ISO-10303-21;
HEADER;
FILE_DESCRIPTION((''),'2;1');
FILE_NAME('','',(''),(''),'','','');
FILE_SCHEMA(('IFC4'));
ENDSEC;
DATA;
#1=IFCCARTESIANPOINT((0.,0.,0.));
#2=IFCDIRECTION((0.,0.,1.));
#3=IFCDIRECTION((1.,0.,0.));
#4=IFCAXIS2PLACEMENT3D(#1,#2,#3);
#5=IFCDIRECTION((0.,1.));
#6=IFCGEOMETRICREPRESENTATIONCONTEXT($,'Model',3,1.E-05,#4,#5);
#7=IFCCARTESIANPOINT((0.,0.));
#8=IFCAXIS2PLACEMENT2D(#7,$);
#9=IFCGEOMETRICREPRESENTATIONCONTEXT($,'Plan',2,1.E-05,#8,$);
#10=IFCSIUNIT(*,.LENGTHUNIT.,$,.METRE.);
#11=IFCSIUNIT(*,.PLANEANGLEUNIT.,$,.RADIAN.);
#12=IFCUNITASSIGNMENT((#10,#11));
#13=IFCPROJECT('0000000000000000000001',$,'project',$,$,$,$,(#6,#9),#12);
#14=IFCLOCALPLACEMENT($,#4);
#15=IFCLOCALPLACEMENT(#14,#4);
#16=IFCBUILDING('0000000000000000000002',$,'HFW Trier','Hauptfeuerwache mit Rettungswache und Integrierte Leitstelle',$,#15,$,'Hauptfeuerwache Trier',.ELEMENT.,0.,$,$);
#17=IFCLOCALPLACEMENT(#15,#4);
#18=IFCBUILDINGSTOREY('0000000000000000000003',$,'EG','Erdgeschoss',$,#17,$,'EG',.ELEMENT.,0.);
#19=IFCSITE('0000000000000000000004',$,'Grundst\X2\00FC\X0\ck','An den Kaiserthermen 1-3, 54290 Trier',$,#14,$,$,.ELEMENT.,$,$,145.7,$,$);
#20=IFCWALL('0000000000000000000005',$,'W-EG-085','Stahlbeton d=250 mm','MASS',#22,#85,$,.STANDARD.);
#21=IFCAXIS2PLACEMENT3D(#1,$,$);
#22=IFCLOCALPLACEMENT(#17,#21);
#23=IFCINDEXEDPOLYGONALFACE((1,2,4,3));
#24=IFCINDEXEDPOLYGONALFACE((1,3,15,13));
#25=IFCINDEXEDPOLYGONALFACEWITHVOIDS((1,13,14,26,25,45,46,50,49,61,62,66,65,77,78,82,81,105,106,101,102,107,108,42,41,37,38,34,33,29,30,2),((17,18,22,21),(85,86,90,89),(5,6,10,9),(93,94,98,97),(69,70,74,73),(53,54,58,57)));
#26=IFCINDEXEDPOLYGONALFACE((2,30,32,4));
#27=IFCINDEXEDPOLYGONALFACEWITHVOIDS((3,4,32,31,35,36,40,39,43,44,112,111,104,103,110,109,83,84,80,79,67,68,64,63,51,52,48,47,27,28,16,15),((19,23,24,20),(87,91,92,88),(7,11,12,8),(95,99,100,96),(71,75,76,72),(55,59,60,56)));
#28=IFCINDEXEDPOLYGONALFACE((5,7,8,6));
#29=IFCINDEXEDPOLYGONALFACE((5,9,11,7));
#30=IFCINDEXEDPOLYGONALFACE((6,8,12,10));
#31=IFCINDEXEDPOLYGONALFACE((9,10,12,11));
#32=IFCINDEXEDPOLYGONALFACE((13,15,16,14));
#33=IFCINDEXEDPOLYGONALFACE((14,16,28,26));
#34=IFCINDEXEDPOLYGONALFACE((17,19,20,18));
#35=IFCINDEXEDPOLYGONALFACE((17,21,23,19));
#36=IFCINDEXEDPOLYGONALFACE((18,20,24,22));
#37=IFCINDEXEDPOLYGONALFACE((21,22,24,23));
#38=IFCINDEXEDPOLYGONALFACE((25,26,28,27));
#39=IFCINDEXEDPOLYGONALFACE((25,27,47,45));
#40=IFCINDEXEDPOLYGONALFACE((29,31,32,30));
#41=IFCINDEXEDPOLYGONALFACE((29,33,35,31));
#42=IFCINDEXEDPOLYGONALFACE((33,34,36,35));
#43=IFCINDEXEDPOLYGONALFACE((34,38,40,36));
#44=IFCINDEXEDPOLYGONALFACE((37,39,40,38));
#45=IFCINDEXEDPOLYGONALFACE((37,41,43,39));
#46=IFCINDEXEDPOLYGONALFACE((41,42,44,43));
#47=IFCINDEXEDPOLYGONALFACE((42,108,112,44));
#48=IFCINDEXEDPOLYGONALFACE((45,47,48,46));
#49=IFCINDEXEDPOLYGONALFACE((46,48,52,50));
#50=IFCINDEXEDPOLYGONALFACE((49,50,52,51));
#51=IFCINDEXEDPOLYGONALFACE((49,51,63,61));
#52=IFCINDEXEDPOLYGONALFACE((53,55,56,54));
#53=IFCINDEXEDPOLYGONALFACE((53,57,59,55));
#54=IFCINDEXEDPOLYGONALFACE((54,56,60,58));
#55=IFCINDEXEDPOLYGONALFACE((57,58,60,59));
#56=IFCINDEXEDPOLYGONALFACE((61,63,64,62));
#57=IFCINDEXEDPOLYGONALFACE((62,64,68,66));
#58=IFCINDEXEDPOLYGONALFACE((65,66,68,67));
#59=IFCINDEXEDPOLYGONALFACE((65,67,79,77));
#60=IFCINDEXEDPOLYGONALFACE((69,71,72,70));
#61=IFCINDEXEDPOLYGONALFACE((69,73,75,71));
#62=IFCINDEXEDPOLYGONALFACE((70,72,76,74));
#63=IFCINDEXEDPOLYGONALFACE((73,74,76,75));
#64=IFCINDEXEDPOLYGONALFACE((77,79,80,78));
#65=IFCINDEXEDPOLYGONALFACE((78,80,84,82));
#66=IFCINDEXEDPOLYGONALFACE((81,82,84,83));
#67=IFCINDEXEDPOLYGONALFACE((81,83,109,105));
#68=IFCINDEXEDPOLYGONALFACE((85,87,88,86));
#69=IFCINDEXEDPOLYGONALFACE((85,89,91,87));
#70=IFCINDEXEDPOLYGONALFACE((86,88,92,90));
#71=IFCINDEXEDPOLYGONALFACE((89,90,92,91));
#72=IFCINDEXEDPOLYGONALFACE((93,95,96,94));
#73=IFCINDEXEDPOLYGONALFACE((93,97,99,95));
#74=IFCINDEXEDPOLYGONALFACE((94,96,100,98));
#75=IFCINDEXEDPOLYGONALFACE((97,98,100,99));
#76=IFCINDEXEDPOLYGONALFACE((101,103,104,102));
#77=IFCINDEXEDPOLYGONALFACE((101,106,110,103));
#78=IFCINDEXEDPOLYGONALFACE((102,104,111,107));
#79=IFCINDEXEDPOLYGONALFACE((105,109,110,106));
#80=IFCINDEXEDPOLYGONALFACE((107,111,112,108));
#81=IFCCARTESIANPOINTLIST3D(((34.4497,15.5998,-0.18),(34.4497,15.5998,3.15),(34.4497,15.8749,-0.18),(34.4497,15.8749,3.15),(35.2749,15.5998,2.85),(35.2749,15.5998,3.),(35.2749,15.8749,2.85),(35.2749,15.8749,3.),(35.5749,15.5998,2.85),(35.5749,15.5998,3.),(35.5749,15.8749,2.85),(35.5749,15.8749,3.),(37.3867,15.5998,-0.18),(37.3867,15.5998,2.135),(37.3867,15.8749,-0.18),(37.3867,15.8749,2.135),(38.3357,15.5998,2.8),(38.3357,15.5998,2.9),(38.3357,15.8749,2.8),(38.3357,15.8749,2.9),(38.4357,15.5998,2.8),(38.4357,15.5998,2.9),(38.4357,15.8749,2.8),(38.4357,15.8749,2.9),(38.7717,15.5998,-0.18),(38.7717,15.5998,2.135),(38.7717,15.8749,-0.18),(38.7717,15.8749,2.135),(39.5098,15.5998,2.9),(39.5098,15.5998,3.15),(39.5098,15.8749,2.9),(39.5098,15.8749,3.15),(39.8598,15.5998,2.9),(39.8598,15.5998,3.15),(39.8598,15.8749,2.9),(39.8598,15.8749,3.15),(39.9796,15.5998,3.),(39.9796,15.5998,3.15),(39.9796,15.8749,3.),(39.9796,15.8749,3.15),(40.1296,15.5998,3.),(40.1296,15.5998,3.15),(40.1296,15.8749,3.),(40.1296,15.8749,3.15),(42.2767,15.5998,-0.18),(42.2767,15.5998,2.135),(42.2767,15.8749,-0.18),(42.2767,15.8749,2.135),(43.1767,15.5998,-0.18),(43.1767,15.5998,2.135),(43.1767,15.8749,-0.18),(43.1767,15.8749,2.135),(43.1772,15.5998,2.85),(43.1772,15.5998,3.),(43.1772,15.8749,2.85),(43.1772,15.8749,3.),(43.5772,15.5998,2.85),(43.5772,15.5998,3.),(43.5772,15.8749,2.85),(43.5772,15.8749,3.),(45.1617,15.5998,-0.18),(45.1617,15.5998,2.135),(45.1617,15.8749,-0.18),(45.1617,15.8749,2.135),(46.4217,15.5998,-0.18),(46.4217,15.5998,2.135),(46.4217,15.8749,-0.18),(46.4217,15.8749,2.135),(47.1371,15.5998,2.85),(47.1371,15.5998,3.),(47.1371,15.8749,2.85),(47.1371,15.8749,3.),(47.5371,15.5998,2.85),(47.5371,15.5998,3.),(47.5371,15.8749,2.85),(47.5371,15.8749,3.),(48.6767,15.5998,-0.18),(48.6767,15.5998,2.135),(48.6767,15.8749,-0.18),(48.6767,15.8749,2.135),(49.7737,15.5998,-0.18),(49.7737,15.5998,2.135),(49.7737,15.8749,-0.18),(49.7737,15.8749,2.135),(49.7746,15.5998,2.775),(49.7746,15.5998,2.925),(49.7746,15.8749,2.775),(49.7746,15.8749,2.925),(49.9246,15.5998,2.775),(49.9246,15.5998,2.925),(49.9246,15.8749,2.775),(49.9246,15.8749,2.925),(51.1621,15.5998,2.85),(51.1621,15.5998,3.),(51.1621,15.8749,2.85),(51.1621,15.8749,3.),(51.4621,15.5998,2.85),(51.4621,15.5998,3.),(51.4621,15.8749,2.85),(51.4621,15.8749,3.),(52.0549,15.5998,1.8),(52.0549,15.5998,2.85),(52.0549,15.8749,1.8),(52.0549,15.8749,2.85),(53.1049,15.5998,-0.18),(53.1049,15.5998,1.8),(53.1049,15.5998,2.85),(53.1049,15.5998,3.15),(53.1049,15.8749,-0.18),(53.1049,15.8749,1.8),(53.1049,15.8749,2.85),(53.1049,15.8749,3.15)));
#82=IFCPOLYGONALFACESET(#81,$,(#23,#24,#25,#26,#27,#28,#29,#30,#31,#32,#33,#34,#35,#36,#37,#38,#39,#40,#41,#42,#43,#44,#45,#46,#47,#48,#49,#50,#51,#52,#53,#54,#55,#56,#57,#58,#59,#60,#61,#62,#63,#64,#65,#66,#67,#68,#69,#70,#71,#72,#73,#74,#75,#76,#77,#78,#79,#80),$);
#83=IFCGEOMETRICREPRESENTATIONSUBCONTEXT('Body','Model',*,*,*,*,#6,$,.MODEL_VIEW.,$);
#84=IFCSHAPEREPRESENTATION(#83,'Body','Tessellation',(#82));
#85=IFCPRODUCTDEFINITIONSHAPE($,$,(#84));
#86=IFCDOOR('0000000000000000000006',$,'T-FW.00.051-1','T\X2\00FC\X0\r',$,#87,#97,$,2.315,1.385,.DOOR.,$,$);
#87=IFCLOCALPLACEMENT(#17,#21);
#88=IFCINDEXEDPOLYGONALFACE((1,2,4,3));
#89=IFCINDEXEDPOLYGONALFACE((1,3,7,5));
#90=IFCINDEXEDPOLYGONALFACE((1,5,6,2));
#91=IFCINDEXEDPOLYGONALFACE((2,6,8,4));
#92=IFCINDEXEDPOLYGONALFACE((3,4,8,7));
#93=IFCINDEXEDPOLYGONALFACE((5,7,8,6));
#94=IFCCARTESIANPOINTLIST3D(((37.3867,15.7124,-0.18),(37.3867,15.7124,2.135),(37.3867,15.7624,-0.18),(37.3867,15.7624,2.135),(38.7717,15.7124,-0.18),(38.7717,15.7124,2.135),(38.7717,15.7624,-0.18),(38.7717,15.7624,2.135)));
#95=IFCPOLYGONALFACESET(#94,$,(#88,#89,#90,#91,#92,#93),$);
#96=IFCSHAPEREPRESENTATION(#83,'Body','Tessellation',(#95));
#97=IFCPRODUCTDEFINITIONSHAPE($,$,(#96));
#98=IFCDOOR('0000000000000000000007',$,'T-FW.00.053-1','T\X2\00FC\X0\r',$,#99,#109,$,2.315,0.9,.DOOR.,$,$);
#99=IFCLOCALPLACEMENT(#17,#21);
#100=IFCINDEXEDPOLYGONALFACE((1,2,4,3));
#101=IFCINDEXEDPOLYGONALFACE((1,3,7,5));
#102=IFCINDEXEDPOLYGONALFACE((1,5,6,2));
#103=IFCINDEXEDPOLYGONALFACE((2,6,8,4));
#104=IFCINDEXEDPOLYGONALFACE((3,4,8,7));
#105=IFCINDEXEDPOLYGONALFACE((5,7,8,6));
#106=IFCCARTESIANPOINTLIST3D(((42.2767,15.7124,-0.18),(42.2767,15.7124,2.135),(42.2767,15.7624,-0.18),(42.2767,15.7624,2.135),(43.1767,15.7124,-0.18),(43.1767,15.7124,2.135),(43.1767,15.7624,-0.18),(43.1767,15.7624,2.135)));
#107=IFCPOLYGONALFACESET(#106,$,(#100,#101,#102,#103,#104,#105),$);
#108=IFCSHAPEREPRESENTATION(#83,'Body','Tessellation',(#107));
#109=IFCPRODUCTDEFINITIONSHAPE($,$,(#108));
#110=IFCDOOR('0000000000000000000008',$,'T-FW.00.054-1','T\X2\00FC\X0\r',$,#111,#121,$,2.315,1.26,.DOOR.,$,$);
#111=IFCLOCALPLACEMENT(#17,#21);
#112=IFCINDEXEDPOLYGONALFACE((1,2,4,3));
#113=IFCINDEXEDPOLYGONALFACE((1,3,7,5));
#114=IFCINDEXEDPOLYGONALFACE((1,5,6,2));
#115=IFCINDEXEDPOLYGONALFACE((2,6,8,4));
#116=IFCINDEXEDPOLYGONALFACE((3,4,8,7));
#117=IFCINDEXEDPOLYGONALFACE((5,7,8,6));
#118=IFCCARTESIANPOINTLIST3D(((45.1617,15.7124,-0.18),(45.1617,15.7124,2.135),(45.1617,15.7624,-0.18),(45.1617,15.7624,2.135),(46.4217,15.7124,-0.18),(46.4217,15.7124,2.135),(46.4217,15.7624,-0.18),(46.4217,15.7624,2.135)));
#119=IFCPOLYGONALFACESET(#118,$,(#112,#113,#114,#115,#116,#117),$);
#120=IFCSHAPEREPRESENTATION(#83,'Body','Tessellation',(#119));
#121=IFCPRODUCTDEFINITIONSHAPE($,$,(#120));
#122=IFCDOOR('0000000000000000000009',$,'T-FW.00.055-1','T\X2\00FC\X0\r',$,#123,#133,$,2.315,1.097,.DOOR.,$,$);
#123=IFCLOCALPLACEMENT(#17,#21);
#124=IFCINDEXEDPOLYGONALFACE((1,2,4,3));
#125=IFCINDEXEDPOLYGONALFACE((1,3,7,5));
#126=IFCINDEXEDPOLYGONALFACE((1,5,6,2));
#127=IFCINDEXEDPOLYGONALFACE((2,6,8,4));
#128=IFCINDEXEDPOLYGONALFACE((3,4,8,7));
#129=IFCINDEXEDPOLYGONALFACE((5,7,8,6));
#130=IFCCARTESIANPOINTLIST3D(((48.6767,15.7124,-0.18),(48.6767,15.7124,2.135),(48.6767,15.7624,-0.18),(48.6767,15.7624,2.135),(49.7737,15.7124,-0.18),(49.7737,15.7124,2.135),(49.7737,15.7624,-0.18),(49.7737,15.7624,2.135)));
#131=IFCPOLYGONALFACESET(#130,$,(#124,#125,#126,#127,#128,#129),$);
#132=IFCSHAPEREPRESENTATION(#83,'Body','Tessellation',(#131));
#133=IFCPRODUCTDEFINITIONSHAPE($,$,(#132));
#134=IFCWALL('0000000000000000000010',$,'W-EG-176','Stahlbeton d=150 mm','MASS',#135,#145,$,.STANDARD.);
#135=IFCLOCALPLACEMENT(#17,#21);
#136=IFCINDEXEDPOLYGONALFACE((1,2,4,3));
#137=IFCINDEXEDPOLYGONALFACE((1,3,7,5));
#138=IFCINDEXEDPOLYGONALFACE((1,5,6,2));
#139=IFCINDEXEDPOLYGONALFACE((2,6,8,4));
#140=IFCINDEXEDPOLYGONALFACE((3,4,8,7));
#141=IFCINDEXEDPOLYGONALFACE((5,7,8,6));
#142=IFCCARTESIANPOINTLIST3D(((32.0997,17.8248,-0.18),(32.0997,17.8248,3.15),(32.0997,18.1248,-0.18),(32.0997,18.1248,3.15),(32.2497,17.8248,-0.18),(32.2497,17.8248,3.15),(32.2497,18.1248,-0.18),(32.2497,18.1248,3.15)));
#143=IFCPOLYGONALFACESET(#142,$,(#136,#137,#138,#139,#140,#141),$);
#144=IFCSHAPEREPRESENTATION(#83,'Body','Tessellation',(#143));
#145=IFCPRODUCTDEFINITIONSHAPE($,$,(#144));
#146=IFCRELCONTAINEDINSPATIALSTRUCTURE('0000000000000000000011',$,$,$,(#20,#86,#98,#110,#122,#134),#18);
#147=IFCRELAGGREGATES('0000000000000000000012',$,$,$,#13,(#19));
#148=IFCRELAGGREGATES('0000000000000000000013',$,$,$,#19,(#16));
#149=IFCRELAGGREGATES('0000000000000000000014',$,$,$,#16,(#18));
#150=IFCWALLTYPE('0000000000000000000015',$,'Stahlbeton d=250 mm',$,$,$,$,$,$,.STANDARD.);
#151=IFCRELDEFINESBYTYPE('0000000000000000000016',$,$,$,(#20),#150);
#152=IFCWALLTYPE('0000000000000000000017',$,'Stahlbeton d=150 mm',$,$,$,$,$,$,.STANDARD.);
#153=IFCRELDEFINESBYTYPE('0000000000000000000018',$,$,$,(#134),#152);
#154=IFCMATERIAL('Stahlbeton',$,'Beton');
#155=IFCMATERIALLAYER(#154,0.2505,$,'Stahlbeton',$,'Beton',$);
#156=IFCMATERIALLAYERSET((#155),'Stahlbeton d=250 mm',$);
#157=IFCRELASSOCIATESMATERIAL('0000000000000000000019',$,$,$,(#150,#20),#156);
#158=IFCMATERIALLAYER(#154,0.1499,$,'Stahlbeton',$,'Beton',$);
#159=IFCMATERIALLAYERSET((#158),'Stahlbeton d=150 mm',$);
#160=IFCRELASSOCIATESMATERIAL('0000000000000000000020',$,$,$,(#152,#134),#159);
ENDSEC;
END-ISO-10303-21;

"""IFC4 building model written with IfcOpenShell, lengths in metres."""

from ifc_helpers import new_model, si_unit, direction, frame, frame_2d, origin_with_axes, origin_2d, place, context, subcontext, project, spatial, rectangle, extrude, material, layer, layer_set, layer_usage, type_object, element, fill, save


model = new_model("IFC4")

# Units and contexts
model_context = context("Model", 3, precision=1e-05, world=origin_with_axes(), true_north=direction((0.0, 1.0)))
plan_context = context("Plan", 2, precision=1e-05, world=origin_2d())
body_context = subcontext(model_context, "Body", "Model", "MODEL_VIEW")
ifc_project = project(units=[si_unit("LENGTHUNIT", "METRE"), si_unit("PLANEANGLEUNIT", "RADIAN")], contexts=[model_context, plan_context])

# Site, building, storey
site_placement = place(None, origin_with_axes())
site = spatial("IfcSite", under=ifc_project, at=site_placement, Name="Grundstück", Description="An den Kaiserthermen 1-3, 54290 Trier", CompositionType="ELEMENT", RefElevation=145.7)
building_placement = place(site_placement, origin_with_axes())
building = spatial("IfcBuilding", under=site, at=building_placement, Name="HFW Trier", Description="Hauptfeuerwache mit Rettungswache und Integrierte Leitstelle", LongName="Hauptfeuerwache Trier", CompositionType="ELEMENT", ElevationOfRefHeight=0.0)
storey_placement = place(building_placement, origin_with_axes())
storey = spatial("IfcBuildingStorey", under=building, at=storey_placement, Name="EG", Description="Erdgeschoss", LongName="EG", CompositionType="ELEMENT", Elevation=0.0)

# Shared definitions
ifc_material = material(Name="Stahlbeton", Category="Beton")

# Wall, openings, doors
ifc_layer_1 = layer(ifc_material, 0.2505, Name="Stahlbeton", Category="Beton")
ifc_layer_set_1 = layer_set([ifc_layer_1], Name="Stahlbeton d=250 mm")
ifc_layer_usage_1 = layer_usage(ifc_layer_set_1, "AXIS2", "POSITIVE", -0.1376)
wall_type_1 = type_object("IfcWallType", Name="Stahlbeton d=250 mm", PredefinedType="STANDARD", material=ifc_layer_set_1)
wall_1_placement = place(storey_placement, frame((34.4497, 15.7374, -0.18), z_axis=(0.0, 0.0, 1.0), x_axis=(1.0, 0.0, 0.0)))
wall_1 = element("IfcWall", 1, at=wall_1_placement, inside=storey, type_object=wall_type_1, material=ifc_layer_usage_1, Name="W-EG-085", Description="Stahlbeton d=250 mm", ObjectType="MASS", PredefinedType="STANDARD", context=body_context, shape_type="SweptSolid", body=[
    extrude(rectangle(XDim=18.6552, YDim=0.2751, at=frame_2d((9.3276, 0.0))), origin_with_axes(), (0.0, 0.0, 1.0), 3.33),
])
opening_1_placement = place(wall_1_placement, frame((2.937, 0.0, 0.0), z_axis=(0.0, 0.0, 1.0), x_axis=(1.0, 0.0, 0.0)))
opening_1 = element("IfcOpeningElement", 2, at=opening_1_placement, cuts=wall_1, PredefinedType="OPENING", context=body_context, shape_type="SweptSolid", body=[
    extrude(rectangle(XDim=1.385, YDim=0.3751, at=frame_2d((0.6925, 0.0))), origin_with_axes(), (0.0, 0.0, 1.0), 2.315),
])
opening_2_placement = place(wall_1_placement, frame((7.827, 0.0, 0.0), z_axis=(0.0, 0.0, 1.0), x_axis=(1.0, 0.0, 0.0)))
opening_2 = element("IfcOpeningElement", 3, at=opening_2_placement, cuts=wall_1, PredefinedType="OPENING", context=body_context, shape_type="SweptSolid", body=[
    extrude(rectangle(XDim=0.9, YDim=0.3751, at=frame_2d((0.45, 0.0))), origin_with_axes(), (0.0, 0.0, 1.0), 2.315),
])
opening_3_placement = place(wall_1_placement, frame((10.712, 0.0, 0.0), z_axis=(0.0, 0.0, 1.0), x_axis=(1.0, 0.0, 0.0)))
opening_3 = element("IfcOpeningElement", 4, at=opening_3_placement, cuts=wall_1, PredefinedType="OPENING", context=body_context, shape_type="SweptSolid", body=[
    extrude(rectangle(XDim=1.26, YDim=0.3751, at=frame_2d((0.63, 0.0))), origin_with_axes(), (0.0, 0.0, 1.0), 2.315),
])
opening_4_placement = place(wall_1_placement, frame((14.227, 0.0, 0.0), z_axis=(0.0, 0.0, 1.0), x_axis=(1.0, 0.0, 0.0)))
opening_4 = element("IfcOpeningElement", 5, at=opening_4_placement, cuts=wall_1, PredefinedType="OPENING", context=body_context, shape_type="SweptSolid", body=[
    extrude(rectangle(XDim=1.097, YDim=0.3751, at=frame_2d((0.5485, 0.0))), origin_with_axes(), (0.0, 0.0, 1.0), 2.315),
])
opening_5_placement = place(wall_1_placement, origin_with_axes())
element("IfcOpeningElement", 6, at=opening_5_placement, cuts=wall_1, ObjectType="Wanddurchbruch", PredefinedType="OPENING", context=body_context, shape_type="SweptSolid", body=[
    extrude(rectangle(XDim=0.3, YDim=0.3751, at=frame_2d((0.9752, 0.0))), frame((0.0, 0.0, 3.03), z_axis=(0.0, 0.0, 1.0), x_axis=(1.0, 0.0, 0.0)), (0.0, 0.0, 1.0), 0.15),
])
opening_6_placement = place(wall_1_placement, origin_with_axes())
element("IfcOpeningElement", 7, at=opening_6_placement, cuts=wall_1, ObjectType="Wanddurchbruch", PredefinedType="OPENING", context=body_context, shape_type="SweptSolid", body=[
    extrude(rectangle(XDim=0.3, YDim=0.3751, at=frame_2d((16.8624, 0.0))), frame((0.0, 0.0, 3.03), z_axis=(0.0, 0.0, 1.0), x_axis=(1.0, 0.0, 0.0)), (0.0, 0.0, 1.0), 0.15),
])
opening_7_placement = place(wall_1_placement, origin_with_axes())
element("IfcOpeningElement", 8, at=opening_7_placement, cuts=wall_1, ObjectType="Wanddurchbruch", PredefinedType="OPENING", context=body_context, shape_type="SweptSolid", body=[
    extrude(rectangle(XDim=0.4, YDim=0.3751, at=frame_2d((12.8874, 0.0))), frame((0.0, 0.0, 3.03), z_axis=(0.0, 0.0, 1.0), x_axis=(1.0, 0.0, 0.0)), (0.0, 0.0, 1.0), 0.15),
])
opening_8_placement = place(wall_1_placement, origin_with_axes())
element("IfcOpeningElement", 9, at=opening_8_placement, cuts=wall_1, ObjectType="Wanddurchbruch", PredefinedType="OPENING", context=body_context, shape_type="SweptSolid", body=[
    extrude(rectangle(XDim=0.4, YDim=0.3751, at=frame_2d((8.9275, 0.0))), frame((0.0, 0.0, 3.03), z_axis=(0.0, 0.0, 1.0), x_axis=(1.0, 0.0, 0.0)), (0.0, 0.0, 1.0), 0.15),
])
opening_9_placement = place(wall_1_placement, origin_with_axes())
element("IfcOpeningElement", 10, at=opening_9_placement, cuts=wall_1, ObjectType="Wanddurchbruch", PredefinedType="OPENING", context=body_context, shape_type="SweptSolid", body=[
    extrude(rectangle(XDim=0.35, YDim=0.3751, at=frame_2d((5.2351, 0.0))), frame((0.0, 0.0, 3.08), z_axis=(0.0, 0.0, 1.0), x_axis=(1.0, 0.0, 0.0)), (0.0, 0.0, 1.0), 0.25),
])
opening_10_placement = place(wall_1_placement, origin_with_axes())
element("IfcOpeningElement", 11, at=opening_10_placement, cuts=wall_1, ObjectType="Wanddurchbruch", PredefinedType="OPENING", context=body_context, shape_type="SweptSolid", body=[
    extrude(rectangle(XDim=0.1, YDim=0.3751, at=frame_2d((3.936, 0.0))), frame((0.0, 0.0, 2.98), z_axis=(0.0, 0.0, 1.0), x_axis=(1.0, 0.0, 0.0)), (0.0, 0.0, 1.0), 0.1),
])
opening_11_placement = place(wall_1_placement, origin_with_axes())
element("IfcOpeningElement", 12, at=opening_11_placement, cuts=wall_1, ObjectType="Wanddurchbruch", PredefinedType="OPENING", context=body_context, shape_type="SweptSolid", body=[
    extrude(rectangle(XDim=0.15, YDim=0.3751, at=frame_2d((15.3999, 0.0))), frame((0.0, 0.0, 2.955), z_axis=(0.0, 0.0, 1.0), x_axis=(1.0, 0.0, 0.0)), (0.0, 0.0, 1.0), 0.15),
])
opening_12_placement = place(wall_1_placement, origin_with_axes())
element("IfcOpeningElement", 13, at=opening_12_placement, cuts=wall_1, ObjectType="Wanddurchbruch", PredefinedType="OPENING", context=body_context, shape_type="SweptSolid", body=[
    extrude(rectangle(XDim=0.15, YDim=0.3751, at=frame_2d((5.6049, 0.0))), frame((0.0, 0.0, 3.18), z_axis=(0.0, 0.0, 1.0), x_axis=(1.0, 0.0, 0.0)), (0.0, 0.0, 1.0), 0.15),
])
opening_13_placement = place(wall_1_placement, origin_with_axes())
element("IfcOpeningElement", 14, at=opening_13_placement, cuts=wall_1, ObjectType="Wanddurchbruch", PredefinedType="OPENING", context=body_context, shape_type="SweptSolid", body=[
    extrude(rectangle(XDim=1.05, YDim=0.3751, at=frame_2d((18.1302, 0.0))), frame((0.0, 0.0, 1.98), z_axis=(0.0, 0.0, 1.0), x_axis=(1.0, 0.0, 0.0)), (0.0, 0.0, 1.0), 1.05),
])
door_1_placement = place(wall_1_placement, frame((2.937, 0.0, 0.0), z_axis=(0.0, 0.0, 1.0), x_axis=(1.0, 0.0, 0.0)))
door_1 = element("IfcDoor", 15, at=door_1_placement, inside=storey, Name="T-FW.00.051-1", Description="Tür", OverallHeight=2.315, OverallWidth=1.385, PredefinedType="DOOR", context=body_context, shape_type="SweptSolid", body=[
    extrude(rectangle(XDim=1.385, YDim=0.05, at=frame_2d((0.6925, 0.0))), origin_with_axes(), (0.0, 0.0, 1.0), 2.315),
])
fill(opening_1, door_1)
door_2_placement = place(wall_1_placement, frame((7.827, 0.0, 0.0), z_axis=(0.0, 0.0, 1.0), x_axis=(1.0, 0.0, 0.0)))
door_2 = element("IfcDoor", 16, at=door_2_placement, inside=storey, Name="T-FW.00.053-1", Description="Tür", OverallHeight=2.315, OverallWidth=0.9, PredefinedType="DOOR", context=body_context, shape_type="SweptSolid", body=[
    extrude(rectangle(XDim=0.9, YDim=0.05, at=frame_2d((0.45, 0.0))), origin_with_axes(), (0.0, 0.0, 1.0), 2.315),
])
fill(opening_2, door_2)
door_3_placement = place(wall_1_placement, frame((10.712, 0.0, 0.0), z_axis=(0.0, 0.0, 1.0), x_axis=(1.0, 0.0, 0.0)))
door_3 = element("IfcDoor", 17, at=door_3_placement, inside=storey, Name="T-FW.00.054-1", Description="Tür", OverallHeight=2.315, OverallWidth=1.26, PredefinedType="DOOR", context=body_context, shape_type="SweptSolid", body=[
    extrude(rectangle(XDim=1.26, YDim=0.05, at=frame_2d((0.63, 0.0))), origin_with_axes(), (0.0, 0.0, 1.0), 2.315),
])
fill(opening_3, door_3)
door_4_placement = place(wall_1_placement, frame((14.227, 0.0, 0.0), z_axis=(0.0, 0.0, 1.0), x_axis=(1.0, 0.0, 0.0)))
door_4 = element("IfcDoor", 18, at=door_4_placement, inside=storey, Name="T-FW.00.055-1", Description="Tür", OverallHeight=2.315, OverallWidth=1.097, PredefinedType="DOOR", context=body_context, shape_type="SweptSolid", body=[
    extrude(rectangle(XDim=1.097, YDim=0.05, at=frame_2d((0.5485, 0.0))), origin_with_axes(), (0.0, 0.0, 1.0), 2.315),
])
fill(opening_4, door_4)

# Wall
ifc_layer_2 = layer(ifc_material, 0.1499, Name="Stahlbeton", Category="Beton")
ifc_layer_set_2 = layer_set([ifc_layer_2], Name="Stahlbeton d=150 mm")
ifc_layer_usage_2 = layer_usage(ifc_layer_set_2, "AXIS2", "POSITIVE", -0.075)
wall_type_2 = type_object("IfcWallType", Name="Stahlbeton d=150 mm", PredefinedType="STANDARD", material=ifc_layer_set_2)
wall_2_placement = place(storey_placement, frame((32.1747, 18.1248, -0.18), z_axis=(0.0, 0.0, 1.0), x_axis=(0.0, -1.0, 0.0)))
element("IfcWall", 19, at=wall_2_placement, inside=storey, type_object=wall_type_2, material=ifc_layer_usage_2, Name="W-EG-176", Description="Stahlbeton d=150 mm", ObjectType="MASS", PredefinedType="STANDARD", context=body_context, shape_type="SweptSolid", body=[
    extrude(rectangle(XDim=0.3, YDim=0.15, at=frame_2d((0.15, 0.0))), origin_with_axes(), (0.0, 0.0, 1.0), 3.33),
])

save(model, "model.ifc")
